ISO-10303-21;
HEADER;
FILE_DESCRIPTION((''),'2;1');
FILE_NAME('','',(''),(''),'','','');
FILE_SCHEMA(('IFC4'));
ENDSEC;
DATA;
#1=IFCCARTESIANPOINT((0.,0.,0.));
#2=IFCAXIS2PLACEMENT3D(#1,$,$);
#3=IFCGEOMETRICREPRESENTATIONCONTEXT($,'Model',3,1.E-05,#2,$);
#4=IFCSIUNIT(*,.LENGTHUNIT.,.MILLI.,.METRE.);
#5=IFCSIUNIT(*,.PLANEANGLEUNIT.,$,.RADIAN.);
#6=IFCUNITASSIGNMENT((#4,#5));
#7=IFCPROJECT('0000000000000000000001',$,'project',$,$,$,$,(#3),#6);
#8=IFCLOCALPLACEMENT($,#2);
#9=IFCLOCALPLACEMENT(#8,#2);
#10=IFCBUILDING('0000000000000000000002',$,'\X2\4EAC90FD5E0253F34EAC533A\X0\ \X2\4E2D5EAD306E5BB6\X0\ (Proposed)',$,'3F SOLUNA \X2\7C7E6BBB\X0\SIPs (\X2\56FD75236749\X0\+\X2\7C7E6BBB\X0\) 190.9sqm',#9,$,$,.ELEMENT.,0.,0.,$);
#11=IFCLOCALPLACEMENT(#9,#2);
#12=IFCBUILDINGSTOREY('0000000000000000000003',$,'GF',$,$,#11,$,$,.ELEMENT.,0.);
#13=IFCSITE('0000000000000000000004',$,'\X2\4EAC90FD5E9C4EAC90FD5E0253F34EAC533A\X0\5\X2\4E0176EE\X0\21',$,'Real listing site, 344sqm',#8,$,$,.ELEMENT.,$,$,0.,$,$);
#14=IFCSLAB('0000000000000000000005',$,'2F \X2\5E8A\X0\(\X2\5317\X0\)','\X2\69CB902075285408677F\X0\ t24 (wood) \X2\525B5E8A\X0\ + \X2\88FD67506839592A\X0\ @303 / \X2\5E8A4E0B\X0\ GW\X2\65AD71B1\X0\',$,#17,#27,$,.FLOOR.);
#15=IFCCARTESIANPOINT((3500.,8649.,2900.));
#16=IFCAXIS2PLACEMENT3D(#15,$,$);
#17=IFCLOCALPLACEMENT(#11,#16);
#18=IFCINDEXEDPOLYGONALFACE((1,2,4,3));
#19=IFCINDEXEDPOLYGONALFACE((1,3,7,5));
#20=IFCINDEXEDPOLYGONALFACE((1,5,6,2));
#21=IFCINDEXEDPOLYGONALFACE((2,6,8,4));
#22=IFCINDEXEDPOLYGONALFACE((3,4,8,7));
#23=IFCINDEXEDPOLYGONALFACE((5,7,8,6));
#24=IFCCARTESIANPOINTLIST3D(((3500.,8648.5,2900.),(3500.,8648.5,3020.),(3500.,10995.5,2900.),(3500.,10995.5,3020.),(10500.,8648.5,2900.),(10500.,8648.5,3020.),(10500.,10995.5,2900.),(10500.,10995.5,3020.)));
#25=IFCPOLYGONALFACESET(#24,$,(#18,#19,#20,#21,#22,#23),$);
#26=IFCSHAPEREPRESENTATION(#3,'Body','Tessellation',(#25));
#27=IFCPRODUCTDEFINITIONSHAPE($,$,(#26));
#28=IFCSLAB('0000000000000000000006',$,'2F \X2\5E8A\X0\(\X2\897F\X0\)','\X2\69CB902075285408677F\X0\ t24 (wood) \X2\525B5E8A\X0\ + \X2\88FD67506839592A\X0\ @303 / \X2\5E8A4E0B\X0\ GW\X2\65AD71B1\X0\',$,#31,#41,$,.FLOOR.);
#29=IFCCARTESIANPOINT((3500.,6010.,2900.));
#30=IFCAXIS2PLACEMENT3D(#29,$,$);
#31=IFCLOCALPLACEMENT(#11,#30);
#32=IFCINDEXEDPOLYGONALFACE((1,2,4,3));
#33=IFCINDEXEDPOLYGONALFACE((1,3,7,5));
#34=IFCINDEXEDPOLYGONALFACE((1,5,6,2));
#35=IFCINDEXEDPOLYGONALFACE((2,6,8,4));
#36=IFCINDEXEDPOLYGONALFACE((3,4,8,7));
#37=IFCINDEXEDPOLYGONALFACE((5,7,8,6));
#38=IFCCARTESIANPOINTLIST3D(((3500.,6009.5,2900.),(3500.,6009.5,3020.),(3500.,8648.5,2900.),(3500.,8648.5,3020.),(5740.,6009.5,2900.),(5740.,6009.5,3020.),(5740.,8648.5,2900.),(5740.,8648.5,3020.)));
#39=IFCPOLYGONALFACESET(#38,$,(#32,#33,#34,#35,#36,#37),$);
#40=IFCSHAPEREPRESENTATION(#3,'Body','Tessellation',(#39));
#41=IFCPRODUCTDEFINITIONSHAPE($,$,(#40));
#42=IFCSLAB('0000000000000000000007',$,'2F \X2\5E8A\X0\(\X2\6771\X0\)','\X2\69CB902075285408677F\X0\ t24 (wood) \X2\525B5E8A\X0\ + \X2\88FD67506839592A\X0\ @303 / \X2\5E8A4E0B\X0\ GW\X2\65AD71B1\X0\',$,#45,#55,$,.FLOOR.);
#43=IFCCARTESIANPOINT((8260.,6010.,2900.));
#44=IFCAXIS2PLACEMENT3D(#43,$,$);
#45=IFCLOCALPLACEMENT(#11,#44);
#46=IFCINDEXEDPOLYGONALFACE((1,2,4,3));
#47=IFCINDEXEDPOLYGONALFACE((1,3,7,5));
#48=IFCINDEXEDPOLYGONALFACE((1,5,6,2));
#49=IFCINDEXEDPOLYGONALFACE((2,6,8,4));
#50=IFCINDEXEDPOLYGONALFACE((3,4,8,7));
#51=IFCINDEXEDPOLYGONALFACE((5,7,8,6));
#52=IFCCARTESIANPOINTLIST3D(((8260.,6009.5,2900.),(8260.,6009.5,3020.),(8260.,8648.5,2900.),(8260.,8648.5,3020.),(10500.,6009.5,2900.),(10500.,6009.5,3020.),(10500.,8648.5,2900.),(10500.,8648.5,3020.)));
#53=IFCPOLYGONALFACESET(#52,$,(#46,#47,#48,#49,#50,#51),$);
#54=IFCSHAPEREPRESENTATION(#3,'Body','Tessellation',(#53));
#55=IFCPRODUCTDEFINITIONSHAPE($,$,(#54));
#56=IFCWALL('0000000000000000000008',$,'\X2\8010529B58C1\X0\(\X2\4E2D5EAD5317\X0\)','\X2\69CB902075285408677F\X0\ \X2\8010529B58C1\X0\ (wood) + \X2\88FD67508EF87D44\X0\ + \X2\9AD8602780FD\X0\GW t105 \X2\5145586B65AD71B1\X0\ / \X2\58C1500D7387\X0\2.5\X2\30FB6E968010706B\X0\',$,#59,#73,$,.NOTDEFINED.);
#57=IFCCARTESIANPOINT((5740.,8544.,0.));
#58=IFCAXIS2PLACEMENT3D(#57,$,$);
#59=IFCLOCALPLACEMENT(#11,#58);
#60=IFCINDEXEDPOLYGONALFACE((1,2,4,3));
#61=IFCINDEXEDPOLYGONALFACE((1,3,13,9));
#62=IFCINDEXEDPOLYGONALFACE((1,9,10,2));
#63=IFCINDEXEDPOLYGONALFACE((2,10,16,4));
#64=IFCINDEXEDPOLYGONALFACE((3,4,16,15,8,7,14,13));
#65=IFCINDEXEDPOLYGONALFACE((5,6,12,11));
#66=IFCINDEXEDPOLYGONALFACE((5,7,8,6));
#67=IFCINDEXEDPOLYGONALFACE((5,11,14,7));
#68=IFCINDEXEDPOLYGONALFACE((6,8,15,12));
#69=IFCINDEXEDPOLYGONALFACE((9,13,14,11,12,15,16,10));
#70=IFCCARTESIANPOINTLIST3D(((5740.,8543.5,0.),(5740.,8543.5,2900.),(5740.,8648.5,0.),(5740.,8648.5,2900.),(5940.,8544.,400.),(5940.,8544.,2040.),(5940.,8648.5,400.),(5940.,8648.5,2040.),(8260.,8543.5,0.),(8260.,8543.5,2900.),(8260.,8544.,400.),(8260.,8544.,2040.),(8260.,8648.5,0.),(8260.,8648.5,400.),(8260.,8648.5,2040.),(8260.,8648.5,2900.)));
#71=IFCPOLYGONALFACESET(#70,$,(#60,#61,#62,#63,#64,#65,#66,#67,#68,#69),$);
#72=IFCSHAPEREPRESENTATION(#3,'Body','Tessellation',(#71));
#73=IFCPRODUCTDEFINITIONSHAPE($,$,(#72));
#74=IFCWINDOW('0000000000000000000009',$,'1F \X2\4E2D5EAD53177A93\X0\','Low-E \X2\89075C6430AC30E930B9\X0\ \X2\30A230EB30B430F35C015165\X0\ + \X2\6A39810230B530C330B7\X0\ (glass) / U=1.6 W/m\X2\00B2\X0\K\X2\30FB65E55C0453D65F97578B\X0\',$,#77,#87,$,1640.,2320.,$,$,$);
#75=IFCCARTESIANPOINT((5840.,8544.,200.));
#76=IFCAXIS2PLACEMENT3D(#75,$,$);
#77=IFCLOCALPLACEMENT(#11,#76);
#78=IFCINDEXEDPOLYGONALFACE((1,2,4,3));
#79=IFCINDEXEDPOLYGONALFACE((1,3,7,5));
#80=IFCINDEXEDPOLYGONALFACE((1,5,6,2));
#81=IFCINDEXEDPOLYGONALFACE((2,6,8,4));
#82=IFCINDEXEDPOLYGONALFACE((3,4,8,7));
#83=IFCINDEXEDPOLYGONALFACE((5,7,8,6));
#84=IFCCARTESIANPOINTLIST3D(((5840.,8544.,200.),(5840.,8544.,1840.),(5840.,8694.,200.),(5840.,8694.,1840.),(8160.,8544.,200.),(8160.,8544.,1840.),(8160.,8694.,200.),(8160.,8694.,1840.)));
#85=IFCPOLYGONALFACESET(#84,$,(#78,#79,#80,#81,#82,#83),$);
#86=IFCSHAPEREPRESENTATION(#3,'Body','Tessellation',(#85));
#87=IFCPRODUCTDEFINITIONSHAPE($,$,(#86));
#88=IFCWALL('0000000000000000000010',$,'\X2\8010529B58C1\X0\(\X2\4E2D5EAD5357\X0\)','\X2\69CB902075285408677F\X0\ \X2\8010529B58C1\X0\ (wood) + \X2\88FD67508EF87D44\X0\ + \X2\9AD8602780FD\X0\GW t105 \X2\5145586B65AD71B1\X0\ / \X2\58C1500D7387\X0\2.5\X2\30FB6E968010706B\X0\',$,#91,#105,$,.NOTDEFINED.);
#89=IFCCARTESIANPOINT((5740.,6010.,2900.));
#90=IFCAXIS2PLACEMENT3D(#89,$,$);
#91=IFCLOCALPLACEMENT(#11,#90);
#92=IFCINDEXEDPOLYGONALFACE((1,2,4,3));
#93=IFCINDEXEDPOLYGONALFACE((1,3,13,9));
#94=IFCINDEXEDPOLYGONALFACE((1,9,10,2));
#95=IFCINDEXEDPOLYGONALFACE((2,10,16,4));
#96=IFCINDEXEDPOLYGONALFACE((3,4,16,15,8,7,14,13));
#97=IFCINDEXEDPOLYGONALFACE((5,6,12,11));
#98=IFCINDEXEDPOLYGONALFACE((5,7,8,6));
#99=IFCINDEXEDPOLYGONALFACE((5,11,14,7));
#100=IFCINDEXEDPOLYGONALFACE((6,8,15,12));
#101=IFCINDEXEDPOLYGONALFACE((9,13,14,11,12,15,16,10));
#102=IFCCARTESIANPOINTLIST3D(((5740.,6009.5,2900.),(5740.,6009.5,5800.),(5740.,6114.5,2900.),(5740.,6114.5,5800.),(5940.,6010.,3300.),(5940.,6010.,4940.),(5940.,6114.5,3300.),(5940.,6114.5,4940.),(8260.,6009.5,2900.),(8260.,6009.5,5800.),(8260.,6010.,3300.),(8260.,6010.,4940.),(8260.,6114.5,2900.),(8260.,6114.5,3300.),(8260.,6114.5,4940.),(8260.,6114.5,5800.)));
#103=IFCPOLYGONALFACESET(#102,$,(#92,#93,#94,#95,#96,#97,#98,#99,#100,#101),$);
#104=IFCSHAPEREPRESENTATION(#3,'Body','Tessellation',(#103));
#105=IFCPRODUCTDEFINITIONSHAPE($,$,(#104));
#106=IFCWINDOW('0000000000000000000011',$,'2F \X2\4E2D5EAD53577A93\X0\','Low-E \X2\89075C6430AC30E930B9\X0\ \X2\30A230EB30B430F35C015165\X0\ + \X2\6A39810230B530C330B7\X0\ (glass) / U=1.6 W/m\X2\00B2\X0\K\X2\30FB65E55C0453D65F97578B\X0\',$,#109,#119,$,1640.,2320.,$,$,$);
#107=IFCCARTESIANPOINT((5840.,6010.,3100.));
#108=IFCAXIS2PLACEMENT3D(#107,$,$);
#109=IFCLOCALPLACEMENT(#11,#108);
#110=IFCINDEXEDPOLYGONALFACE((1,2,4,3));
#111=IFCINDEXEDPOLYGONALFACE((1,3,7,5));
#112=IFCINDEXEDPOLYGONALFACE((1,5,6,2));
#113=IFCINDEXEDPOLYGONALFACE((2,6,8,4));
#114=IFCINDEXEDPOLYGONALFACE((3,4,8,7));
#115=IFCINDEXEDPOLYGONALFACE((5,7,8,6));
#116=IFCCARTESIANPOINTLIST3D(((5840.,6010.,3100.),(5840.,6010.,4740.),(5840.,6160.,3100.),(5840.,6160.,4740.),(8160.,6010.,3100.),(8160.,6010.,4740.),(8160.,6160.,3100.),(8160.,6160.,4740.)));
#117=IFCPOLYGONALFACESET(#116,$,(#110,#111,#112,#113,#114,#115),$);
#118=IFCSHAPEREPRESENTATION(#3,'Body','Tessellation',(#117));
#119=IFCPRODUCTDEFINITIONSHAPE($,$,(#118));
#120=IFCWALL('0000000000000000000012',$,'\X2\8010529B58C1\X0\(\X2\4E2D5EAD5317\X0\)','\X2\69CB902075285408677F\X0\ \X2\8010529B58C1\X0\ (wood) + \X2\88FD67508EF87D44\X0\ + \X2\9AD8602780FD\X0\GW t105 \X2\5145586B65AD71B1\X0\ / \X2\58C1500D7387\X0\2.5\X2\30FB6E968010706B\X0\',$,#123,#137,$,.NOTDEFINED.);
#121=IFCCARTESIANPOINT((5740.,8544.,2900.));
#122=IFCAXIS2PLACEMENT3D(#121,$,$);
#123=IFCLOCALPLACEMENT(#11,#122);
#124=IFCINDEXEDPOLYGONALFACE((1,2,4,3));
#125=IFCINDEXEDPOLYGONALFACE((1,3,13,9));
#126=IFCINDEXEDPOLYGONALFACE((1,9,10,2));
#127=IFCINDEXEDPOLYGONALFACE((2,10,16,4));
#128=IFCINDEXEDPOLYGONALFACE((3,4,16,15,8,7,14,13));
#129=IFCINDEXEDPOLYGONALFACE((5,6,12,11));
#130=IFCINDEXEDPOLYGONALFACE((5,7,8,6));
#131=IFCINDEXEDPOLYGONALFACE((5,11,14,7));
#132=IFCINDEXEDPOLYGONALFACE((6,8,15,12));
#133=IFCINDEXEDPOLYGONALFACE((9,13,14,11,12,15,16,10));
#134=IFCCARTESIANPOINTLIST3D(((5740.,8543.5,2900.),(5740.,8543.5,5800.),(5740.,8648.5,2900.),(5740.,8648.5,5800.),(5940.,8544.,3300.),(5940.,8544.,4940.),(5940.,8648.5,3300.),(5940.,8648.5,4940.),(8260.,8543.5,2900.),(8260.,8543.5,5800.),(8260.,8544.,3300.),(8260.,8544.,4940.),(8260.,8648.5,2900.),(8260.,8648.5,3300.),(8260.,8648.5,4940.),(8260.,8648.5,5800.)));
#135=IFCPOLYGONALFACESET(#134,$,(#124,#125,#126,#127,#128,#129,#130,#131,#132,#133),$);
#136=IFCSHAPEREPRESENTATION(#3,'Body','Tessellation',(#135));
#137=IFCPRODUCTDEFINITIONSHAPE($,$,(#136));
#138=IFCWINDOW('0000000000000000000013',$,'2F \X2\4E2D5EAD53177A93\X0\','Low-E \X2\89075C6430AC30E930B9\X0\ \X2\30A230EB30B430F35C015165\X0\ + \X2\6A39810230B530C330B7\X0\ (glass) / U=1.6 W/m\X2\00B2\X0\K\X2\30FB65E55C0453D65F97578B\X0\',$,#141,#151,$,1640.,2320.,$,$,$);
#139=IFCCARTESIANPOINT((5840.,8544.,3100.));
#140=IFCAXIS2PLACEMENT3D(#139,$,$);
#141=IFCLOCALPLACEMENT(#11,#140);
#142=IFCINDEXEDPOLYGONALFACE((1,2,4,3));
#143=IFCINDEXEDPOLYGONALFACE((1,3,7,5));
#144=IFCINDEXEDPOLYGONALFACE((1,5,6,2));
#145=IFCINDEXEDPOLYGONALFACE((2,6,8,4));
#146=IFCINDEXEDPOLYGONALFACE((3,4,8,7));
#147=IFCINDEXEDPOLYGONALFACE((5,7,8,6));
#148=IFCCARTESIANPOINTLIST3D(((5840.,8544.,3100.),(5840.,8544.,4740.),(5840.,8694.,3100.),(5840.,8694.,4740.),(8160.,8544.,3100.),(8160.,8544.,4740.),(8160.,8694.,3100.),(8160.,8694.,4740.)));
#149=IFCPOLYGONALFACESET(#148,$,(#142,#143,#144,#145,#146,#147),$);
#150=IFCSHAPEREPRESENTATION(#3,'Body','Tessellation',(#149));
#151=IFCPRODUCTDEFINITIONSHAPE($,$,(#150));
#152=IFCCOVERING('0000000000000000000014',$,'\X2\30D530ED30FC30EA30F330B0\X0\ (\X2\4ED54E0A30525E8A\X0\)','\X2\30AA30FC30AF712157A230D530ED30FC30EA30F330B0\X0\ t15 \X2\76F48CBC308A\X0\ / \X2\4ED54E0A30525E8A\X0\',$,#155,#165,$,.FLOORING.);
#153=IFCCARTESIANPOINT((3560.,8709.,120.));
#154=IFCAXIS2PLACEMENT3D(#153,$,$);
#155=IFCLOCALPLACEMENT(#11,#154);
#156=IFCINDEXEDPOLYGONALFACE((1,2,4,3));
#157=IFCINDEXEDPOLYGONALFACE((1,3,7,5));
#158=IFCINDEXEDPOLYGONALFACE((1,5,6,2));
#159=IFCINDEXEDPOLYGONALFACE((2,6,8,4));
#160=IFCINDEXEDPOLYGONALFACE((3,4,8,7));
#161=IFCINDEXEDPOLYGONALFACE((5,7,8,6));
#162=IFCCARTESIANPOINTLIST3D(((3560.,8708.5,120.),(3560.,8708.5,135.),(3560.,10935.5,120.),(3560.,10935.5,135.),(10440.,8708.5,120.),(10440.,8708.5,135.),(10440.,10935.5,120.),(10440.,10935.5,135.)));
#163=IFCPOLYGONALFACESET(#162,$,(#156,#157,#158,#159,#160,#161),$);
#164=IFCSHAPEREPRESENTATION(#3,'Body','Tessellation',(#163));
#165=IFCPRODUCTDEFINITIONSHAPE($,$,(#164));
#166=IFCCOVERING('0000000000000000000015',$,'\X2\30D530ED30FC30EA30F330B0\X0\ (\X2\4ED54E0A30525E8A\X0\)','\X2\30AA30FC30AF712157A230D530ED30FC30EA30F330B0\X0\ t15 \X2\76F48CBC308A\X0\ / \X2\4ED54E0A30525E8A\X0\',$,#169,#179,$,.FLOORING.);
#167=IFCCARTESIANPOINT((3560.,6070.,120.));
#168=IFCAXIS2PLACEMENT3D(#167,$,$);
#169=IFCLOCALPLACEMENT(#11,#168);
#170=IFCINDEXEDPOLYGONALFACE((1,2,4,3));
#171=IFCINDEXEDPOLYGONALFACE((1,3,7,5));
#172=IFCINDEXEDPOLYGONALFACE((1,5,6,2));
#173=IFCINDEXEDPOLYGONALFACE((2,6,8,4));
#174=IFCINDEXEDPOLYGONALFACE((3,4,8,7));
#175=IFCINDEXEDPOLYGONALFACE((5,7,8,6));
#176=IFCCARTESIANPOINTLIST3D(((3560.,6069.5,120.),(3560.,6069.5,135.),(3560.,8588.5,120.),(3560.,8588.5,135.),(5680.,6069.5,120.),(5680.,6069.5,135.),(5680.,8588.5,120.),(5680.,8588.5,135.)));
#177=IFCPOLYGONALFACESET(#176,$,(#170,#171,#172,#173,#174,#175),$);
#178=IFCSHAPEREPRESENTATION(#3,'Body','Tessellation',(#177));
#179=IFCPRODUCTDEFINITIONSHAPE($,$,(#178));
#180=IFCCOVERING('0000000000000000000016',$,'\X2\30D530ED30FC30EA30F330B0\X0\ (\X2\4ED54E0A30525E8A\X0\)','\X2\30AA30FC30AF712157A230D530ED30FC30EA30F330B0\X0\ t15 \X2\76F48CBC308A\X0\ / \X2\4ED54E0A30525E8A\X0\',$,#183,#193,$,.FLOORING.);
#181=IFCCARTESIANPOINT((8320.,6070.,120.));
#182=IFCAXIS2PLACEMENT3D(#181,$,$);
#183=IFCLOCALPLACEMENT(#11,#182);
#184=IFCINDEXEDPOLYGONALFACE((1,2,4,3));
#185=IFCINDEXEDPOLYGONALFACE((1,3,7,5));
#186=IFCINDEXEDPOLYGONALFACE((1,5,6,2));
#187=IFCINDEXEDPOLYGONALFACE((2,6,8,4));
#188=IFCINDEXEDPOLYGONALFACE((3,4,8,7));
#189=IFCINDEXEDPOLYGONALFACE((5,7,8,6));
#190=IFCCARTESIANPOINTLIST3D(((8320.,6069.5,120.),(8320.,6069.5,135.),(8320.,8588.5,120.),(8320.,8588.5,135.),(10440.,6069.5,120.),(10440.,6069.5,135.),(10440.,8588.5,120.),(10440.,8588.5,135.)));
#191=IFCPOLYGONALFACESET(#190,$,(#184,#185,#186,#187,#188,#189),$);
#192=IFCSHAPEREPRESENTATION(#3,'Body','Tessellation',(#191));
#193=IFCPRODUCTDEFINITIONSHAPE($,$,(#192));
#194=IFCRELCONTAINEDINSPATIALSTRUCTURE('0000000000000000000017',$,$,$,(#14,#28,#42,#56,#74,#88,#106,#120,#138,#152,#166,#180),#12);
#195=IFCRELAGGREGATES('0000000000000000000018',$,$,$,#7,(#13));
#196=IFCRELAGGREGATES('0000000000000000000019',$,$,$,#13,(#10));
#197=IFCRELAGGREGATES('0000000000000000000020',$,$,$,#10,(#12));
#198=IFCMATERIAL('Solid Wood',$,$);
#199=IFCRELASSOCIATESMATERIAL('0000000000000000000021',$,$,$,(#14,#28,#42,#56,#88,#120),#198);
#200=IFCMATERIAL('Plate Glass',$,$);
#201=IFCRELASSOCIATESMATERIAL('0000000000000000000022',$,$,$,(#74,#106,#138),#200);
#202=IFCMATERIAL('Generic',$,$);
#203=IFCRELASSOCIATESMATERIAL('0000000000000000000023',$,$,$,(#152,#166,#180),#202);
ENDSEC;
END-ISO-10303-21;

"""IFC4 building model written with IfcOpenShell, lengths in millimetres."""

from ifc_helpers import new_model, si_unit, frame, frame_2d, origin, place, context, project, spatial, rectangle, extrude, material, element, fill, save


model = new_model("IFC4")

# Units and contexts
model_context = context("Model", 3, precision=1e-05, world=origin())
ifc_project = project(units=[si_unit("LENGTHUNIT", "METRE", prefix="MILLI"), si_unit("PLANEANGLEUNIT", "RADIAN")], contexts=[model_context])

# Site, building, storey
site_placement = place(None, origin())
site = spatial("IfcSite", under=ifc_project, at=site_placement, Name="京都府京都市右京区5丁目21", ObjectType="Real listing site, 344sqm", CompositionType="ELEMENT", RefElevation=0.0)
building_placement = place(site_placement, origin())
building = spatial("IfcBuilding", under=site, at=building_placement, Name="京都市右京区 中庭の家 (Proposed)", ObjectType="3F SOLUNA 籾殻SIPs (国産杉+籾殻) 190.9sqm", CompositionType="ELEMENT", ElevationOfRefHeight=0.0, ElevationOfTerrain=0.0)
storey_placement = place(building_placement, origin())
storey = spatial("IfcBuildingStorey", under=building, at=storey_placement, Name="GF", CompositionType="ELEMENT", Elevation=0.0)

# Slabs
ifc_material_1 = material(Name="Solid Wood")
slab_1_placement = place(storey_placement, frame((3500.0, 8649.0, 2900.0)))
element("IfcSlab", 1, at=slab_1_placement, inside=storey, material=ifc_material_1, Name="2F 床(北)", Description="構造用合板 t24 (wood) 剛床 + 製材根太 @303 / 床下 GW断熱", PredefinedType="FLOOR", context=model_context, shape_type="SweptSolid", body=[
    extrude(rectangle(XDim=7000.0, YDim=2347.0, at=frame_2d((3500.0, 1173.0))), frame((3500.0, 8649.0, 2900.0)), (0.0, 0.0, 1.0), 120.0),
])
slab_2_placement = place(storey_placement, frame((3500.0, 6010.0, 2900.0)))
element("IfcSlab", 2, at=slab_2_placement, inside=storey, material=ifc_material_1, Name="2F 床(西)", Description="構造用合板 t24 (wood) 剛床 + 製材根太 @303 / 床下 GW断熱", PredefinedType="FLOOR", context=model_context, shape_type="SweptSolid", body=[
    extrude(rectangle(XDim=2240.0, YDim=2639.0, at=frame_2d((1120.0, 1319.0))), frame((3500.0, 6010.0, 2900.0)), (0.0, 0.0, 1.0), 120.0),
])
slab_3_placement = place(storey_placement, frame((8260.0, 6010.0, 2900.0)))
element("IfcSlab", 3, at=slab_3_placement, inside=storey, material=ifc_material_1, Name="2F 床(東)", Description="構造用合板 t24 (wood) 剛床 + 製材根太 @303 / 床下 GW断熱", PredefinedType="FLOOR", context=model_context, shape_type="SweptSolid", body=[
    extrude(rectangle(XDim=2240.0, YDim=2639.0, at=frame_2d((1120.0, 1319.0))), frame((8260.0, 6010.0, 2900.0)), (0.0, 0.0, 1.0), 120.0),
])

# Wall, opening, window
wall_1_placement = place(storey_placement, frame((5740.0, 8544.0, 0.0)))
wall_1 = element("IfcWall", 4, at=wall_1_placement, inside=storey, material=ifc_material_1, Name="耐力壁(中庭北)", Description="構造用合板 耐力壁 (wood) + 製材軸組 + 高性能GW t105 充填断熱 / 壁倍率2.5・準耐火", PredefinedType="NOTDEFINED", context=model_context, shape_type="SweptSolid", body=[
    extrude(rectangle(XDim=2520.0, YDim=105.0, at=frame_2d((1260.0, 52.0))), frame((5740.0, 8544.0, 0.0)), (0.0, 0.0, 1.0), 2900.0),
])
opening_1_placement = place(storey_placement, frame((5840.0, 8544.0, 200.0)))
opening_1 = element("IfcOpeningElement", 5, at=opening_1_placement, cuts=wall_1, PredefinedType="NOTDEFINED", context=model_context, shape_type="SweptSolid", body=[
    extrude(rectangle(XDim=2320.0, YDim=150.0, at=frame_2d((1160.0, 75.0))), frame((5840.0, 8544.0, 200.0)), (0.0, 0.0, 1.0), 1640.0),
])
ifc_material_2 = material(Name="Plate Glass")
window_1_placement = place(storey_placement, frame((5840.0, 8544.0, 200.0)))
window_1 = element("IfcWindow", 6, at=window_1_placement, inside=storey, material=ifc_material_2, Name="1F 中庭北窓", Description="Low-E 複層ガラス アルゴン封入 + 樹脂サッシ (glass) / U=1.6 W/m²K・日射取得型", OverallHeight=1640.0, OverallWidth=2320.0, context=model_context, shape_type="SweptSolid", body=[
    extrude(rectangle(XDim=2320.0, YDim=150.0, at=frame_2d((1160.0, 75.0))), frame((5840.0, 8544.0, 200.0)), (0.0, 0.0, 1.0), 1640.0),
])
fill(opening_1, window_1)

# Walls, openings, windows
wall_2_placement = place(storey_placement, frame((5740.0, 6010.0, 2900.0)))
wall_2 = element("IfcWall", 7, at=wall_2_placement, inside=storey, material=ifc_material_1, Name="耐力壁(中庭南)", Description="構造用合板 耐力壁 (wood) + 製材軸組 + 高性能GW t105 充填断熱 / 壁倍率2.5・準耐火", PredefinedType="NOTDEFINED", context=model_context, shape_type="SweptSolid", body=[
    extrude(rectangle(XDim=2520.0, YDim=105.0, at=frame_2d((1260.0, 52.0))), frame((5740.0, 6010.0, 2900.0)), (0.0, 0.0, 1.0), 2900.0),
])
opening_2_placement = place(storey_placement, frame((5840.0, 6010.0, 3100.0)))
opening_2 = element("IfcOpeningElement", 8, at=opening_2_placement, cuts=wall_2, PredefinedType="NOTDEFINED", context=model_context, shape_type="SweptSolid", body=[
    extrude(rectangle(XDim=2320.0, YDim=150.0, at=frame_2d((1160.0, 75.0))), frame((5840.0, 6010.0, 3100.0)), (0.0, 0.0, 1.0), 1640.0),
])
window_2_placement = place(storey_placement, frame((5840.0, 6010.0, 3100.0)))
window_2 = element("IfcWindow", 9, at=window_2_placement, inside=storey, material=ifc_material_2, Name="2F 中庭南窓", Description="Low-E 複層ガラス アルゴン封入 + 樹脂サッシ (glass) / U=1.6 W/m²K・日射取得型", OverallHeight=1640.0, OverallWidth=2320.0, context=model_context, shape_type="SweptSolid", body=[
    extrude(rectangle(XDim=2320.0, YDim=150.0, at=frame_2d((1160.0, 75.0))), frame((5840.0, 6010.0, 3100.0)), (0.0, 0.0, 1.0), 1640.0),
])
fill(opening_2, window_2)
wall_3_placement = place(storey_placement, frame((5740.0, 8544.0, 2900.0)))
wall_3 = element("IfcWall", 10, at=wall_3_placement, inside=storey, material=ifc_material_1, Name="耐力壁(中庭北)", Description="構造用合板 耐力壁 (wood) + 製材軸組 + 高性能GW t105 充填断熱 / 壁倍率2.5・準耐火", PredefinedType="NOTDEFINED", context=model_context, shape_type="SweptSolid", body=[
    extrude(rectangle(XDim=2520.0, YDim=105.0, at=frame_2d((1260.0, 52.0))), frame((5740.0, 8544.0, 2900.0)), (0.0, 0.0, 1.0), 2900.0),
])
opening_3_placement = place(storey_placement, frame((5840.0, 8544.0, 3100.0)))
opening_3 = element("IfcOpeningElement", 11, at=opening_3_placement, cuts=wall_3, PredefinedType="NOTDEFINED", context=model_context, shape_type="SweptSolid", body=[
    extrude(rectangle(XDim=2320.0, YDim=150.0, at=frame_2d((1160.0, 75.0))), frame((5840.0, 8544.0, 3100.0)), (0.0, 0.0, 1.0), 1640.0),
])
window_3_placement = place(storey_placement, frame((5840.0, 8544.0, 3100.0)))
window_3 = element("IfcWindow", 12, at=window_3_placement, inside=storey, material=ifc_material_2, Name="2F 中庭北窓", Description="Low-E 複層ガラス アルゴン封入 + 樹脂サッシ (glass) / U=1.6 W/m²K・日射取得型", OverallHeight=1640.0, OverallWidth=2320.0, context=model_context, shape_type="SweptSolid", body=[
    extrude(rectangle(XDim=2320.0, YDim=150.0, at=frame_2d((1160.0, 75.0))), frame((5840.0, 8544.0, 3100.0)), (0.0, 0.0, 1.0), 1640.0),
])
fill(opening_3, window_3)

# Coverings
ifc_material_3 = material(Name="Generic")
covering_1_placement = place(storey_placement, frame((3560.0, 8709.0, 120.0)))
element("IfcCovering", 13, at=covering_1_placement, inside=storey, material=ifc_material_3, Name="フローリング (仕上げ床)", Description="オーク無垢フローリング t15 直貼り / 仕上げ床", PredefinedType="FLOORING", context=model_context, shape_type="SweptSolid", body=[
    extrude(rectangle(XDim=6880.0, YDim=2227.0, at=frame_2d((3440.0, 1113.0))), frame((3560.0, 8709.0, 120.0)), (0.0, 0.0, 1.0), 15.0),
])
covering_2_placement = place(storey_placement, frame((3560.0, 6070.0, 120.0)))
element("IfcCovering", 14, at=covering_2_placement, inside=storey, material=ifc_material_3, Name="フローリング (仕上げ床)", Description="オーク無垢フローリング t15 直貼り / 仕上げ床", PredefinedType="FLOORING", context=model_context, shape_type="SweptSolid", body=[
    extrude(rectangle(XDim=2120.0, YDim=2519.0, at=frame_2d((1060.0, 1259.0))), frame((3560.0, 6070.0, 120.0)), (0.0, 0.0, 1.0), 15.0),
])
covering_3_placement = place(storey_placement, frame((8320.0, 6070.0, 120.0)))
element("IfcCovering", 15, at=covering_3_placement, inside=storey, material=ifc_material_3, Name="フローリング (仕上げ床)", Description="オーク無垢フローリング t15 直貼り / 仕上げ床", PredefinedType="FLOORING", context=model_context, shape_type="SweptSolid", body=[
    extrude(rectangle(XDim=2120.0, YDim=2519.0, at=frame_2d((1060.0, 1259.0))), frame((8320.0, 6070.0, 120.0)), (0.0, 0.0, 1.0), 15.0),
])

save(model, "model.ifc")
